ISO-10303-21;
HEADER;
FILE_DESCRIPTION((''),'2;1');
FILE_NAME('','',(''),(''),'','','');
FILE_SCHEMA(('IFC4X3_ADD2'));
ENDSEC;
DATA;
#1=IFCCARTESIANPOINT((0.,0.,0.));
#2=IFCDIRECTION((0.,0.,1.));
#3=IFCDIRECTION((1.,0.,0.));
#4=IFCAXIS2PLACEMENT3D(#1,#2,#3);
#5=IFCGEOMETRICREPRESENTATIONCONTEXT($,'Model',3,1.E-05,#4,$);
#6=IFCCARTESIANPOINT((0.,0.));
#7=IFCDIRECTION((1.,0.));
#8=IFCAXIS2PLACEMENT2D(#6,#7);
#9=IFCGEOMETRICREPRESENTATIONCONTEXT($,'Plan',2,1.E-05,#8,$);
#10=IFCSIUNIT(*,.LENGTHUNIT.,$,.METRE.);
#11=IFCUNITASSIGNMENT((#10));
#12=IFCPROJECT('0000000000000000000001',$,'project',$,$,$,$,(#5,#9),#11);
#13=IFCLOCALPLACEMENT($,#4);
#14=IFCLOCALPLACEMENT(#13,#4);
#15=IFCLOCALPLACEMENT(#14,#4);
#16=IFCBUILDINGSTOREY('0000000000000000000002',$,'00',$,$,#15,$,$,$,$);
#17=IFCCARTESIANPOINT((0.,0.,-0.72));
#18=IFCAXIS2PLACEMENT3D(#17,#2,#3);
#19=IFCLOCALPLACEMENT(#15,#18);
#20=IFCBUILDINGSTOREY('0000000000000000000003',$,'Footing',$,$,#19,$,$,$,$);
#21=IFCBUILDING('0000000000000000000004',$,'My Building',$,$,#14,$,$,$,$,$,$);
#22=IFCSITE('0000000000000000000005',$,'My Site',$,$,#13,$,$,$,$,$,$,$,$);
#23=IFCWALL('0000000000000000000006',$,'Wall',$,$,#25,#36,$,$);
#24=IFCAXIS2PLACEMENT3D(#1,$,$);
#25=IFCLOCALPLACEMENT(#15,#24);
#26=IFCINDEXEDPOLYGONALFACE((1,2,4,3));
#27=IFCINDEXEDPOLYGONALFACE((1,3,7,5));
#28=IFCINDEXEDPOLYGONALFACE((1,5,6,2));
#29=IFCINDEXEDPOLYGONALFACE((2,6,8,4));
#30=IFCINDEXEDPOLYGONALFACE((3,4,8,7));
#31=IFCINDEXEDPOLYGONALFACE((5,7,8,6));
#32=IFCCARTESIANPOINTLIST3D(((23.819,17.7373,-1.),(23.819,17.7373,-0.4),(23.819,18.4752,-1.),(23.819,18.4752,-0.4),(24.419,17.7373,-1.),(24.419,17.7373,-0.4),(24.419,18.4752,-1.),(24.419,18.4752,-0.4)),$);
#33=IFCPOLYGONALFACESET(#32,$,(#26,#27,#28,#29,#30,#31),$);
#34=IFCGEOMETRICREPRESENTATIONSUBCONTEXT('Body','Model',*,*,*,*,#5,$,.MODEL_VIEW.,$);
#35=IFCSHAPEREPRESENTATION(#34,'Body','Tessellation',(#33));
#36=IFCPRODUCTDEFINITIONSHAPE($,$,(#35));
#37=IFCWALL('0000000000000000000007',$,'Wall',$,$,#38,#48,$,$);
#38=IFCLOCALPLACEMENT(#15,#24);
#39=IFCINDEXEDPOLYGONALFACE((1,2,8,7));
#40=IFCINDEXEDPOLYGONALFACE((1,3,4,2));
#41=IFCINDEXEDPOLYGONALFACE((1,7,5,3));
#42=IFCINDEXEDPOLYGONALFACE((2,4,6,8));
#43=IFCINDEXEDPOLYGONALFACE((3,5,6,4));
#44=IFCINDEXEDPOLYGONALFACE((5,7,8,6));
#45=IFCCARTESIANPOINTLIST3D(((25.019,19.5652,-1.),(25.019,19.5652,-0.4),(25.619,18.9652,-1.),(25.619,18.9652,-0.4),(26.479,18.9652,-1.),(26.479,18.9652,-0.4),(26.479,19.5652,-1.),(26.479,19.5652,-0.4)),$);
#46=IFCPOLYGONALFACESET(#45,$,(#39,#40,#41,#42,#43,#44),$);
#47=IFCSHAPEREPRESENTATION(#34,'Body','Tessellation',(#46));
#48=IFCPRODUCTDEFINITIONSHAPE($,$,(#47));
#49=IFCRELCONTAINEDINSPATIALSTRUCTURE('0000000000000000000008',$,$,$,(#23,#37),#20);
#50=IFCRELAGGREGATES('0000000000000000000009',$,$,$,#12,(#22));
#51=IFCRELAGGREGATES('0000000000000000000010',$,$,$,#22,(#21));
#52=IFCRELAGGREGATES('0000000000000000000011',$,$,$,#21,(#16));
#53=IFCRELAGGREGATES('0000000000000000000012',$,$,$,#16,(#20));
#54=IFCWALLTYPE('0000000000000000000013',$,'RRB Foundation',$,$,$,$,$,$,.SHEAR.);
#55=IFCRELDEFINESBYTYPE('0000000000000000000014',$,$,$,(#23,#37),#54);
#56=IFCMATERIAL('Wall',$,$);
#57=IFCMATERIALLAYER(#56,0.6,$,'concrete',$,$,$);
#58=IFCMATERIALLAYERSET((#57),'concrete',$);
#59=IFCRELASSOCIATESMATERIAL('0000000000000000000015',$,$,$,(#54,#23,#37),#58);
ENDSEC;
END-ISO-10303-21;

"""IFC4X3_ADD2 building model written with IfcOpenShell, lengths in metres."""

from ifc_helpers import new_model, si_unit, frame, origin_with_axes, origin_2d_with_axis, place, context, subcontext, project, spatial, line, indexed_curve, outline, extrude, material, layer, layer_set, layer_usage, type_object, element, save


model = new_model("IFC4X3_ADD2")

# Units and contexts
model_context = context("Model", 3, precision=1e-05, world=origin_with_axes())
plan_context = context("Plan", 2, precision=1e-05, world=origin_2d_with_axis())
body_context = subcontext(model_context, "Body", "Model", "MODEL_VIEW")
ifc_project = project(units=[si_unit("LENGTHUNIT", "METRE")], contexts=[model_context, plan_context])

# Site, building, storeys
site_placement = place(None, origin_with_axes())
site = spatial("IfcSite", under=ifc_project, at=site_placement, Name="My Site")
building_placement = place(site_placement, origin_with_axes())
building = spatial("IfcBuilding", under=site, at=building_placement, Name="My Building")
storey_1_placement = place(building_placement, origin_with_axes())
storey_1 = spatial("IfcBuildingStorey", under=building, at=storey_1_placement, Name="00")
storey_2_placement = place(storey_1_placement, frame((0.0, 0.0, -0.72), z_axis=(0.0, 0.0, 1.0), x_axis=(1.0, 0.0, 0.0)))
storey_2 = spatial("IfcBuildingStorey", under=storey_1, at=storey_2_placement, Name="Footing")

# Shared definitions
ifc_material_1 = material(Name="Wall")

# Walls
ifc_layer_1 = layer(ifc_material_1, 0.6, Name="concrete")
ifc_layer_set_1 = layer_set([ifc_layer_1], Name="concrete")
ifc_layer_usage_1 = layer_usage(ifc_layer_set_1, "AXIS2", "POSITIVE", 0.0)
wall_type_1 = type_object("IfcWallType", Name="RRB Foundation", PredefinedType="SHEAR", material=ifc_layer_set_1)
wall_1_placement = place(storey_2_placement, frame((24.419, 17.7373, -0.28), z_axis=(0.0, 0.0, 1.0), x_axis=(0.000001, 1.0, 0.0)))
element("IfcWall", 1, at=wall_1_placement, inside=storey_2, type_object=wall_type_1, material=ifc_layer_usage_1, Name="Wall", context=body_context, shape_type="SweptSolid", body=[
    extrude(outline(indexed_curve([(0.0, 0.0), (0.0, 0.6), (0.7379, 0.6), (0.7379, 0.0)], segments=[line(1, 2, 3, 4, 1)])), origin_with_axes(), (0.0, 0.0, 1.0), 0.6),
])
ifc_layer_usage_2 = layer_usage(ifc_layer_set_1, "AXIS2", "POSITIVE", 0.0)
wall_2_placement = place(storey_2_placement, frame((25.619, 18.9652, -0.28), z_axis=(0.0, 0.0, 1.0), x_axis=(1.0, 0.0, 0.0)))
element("IfcWall", 2, at=wall_2_placement, inside=storey_2, type_object=wall_type_1, material=ifc_layer_usage_2, Name="Wall", context=body_context, shape_type="SweptSolid", body=[
    extrude(outline(indexed_curve([(0.0, 0.0), (-0.6, 0.6), (0.86, 0.6), (0.86, 0.0)], segments=[line(1, 2, 3, 4, 1)])), origin_with_axes(), (0.0, 0.0, 1.0), 0.6),
])

save(model, "model.ifc")
